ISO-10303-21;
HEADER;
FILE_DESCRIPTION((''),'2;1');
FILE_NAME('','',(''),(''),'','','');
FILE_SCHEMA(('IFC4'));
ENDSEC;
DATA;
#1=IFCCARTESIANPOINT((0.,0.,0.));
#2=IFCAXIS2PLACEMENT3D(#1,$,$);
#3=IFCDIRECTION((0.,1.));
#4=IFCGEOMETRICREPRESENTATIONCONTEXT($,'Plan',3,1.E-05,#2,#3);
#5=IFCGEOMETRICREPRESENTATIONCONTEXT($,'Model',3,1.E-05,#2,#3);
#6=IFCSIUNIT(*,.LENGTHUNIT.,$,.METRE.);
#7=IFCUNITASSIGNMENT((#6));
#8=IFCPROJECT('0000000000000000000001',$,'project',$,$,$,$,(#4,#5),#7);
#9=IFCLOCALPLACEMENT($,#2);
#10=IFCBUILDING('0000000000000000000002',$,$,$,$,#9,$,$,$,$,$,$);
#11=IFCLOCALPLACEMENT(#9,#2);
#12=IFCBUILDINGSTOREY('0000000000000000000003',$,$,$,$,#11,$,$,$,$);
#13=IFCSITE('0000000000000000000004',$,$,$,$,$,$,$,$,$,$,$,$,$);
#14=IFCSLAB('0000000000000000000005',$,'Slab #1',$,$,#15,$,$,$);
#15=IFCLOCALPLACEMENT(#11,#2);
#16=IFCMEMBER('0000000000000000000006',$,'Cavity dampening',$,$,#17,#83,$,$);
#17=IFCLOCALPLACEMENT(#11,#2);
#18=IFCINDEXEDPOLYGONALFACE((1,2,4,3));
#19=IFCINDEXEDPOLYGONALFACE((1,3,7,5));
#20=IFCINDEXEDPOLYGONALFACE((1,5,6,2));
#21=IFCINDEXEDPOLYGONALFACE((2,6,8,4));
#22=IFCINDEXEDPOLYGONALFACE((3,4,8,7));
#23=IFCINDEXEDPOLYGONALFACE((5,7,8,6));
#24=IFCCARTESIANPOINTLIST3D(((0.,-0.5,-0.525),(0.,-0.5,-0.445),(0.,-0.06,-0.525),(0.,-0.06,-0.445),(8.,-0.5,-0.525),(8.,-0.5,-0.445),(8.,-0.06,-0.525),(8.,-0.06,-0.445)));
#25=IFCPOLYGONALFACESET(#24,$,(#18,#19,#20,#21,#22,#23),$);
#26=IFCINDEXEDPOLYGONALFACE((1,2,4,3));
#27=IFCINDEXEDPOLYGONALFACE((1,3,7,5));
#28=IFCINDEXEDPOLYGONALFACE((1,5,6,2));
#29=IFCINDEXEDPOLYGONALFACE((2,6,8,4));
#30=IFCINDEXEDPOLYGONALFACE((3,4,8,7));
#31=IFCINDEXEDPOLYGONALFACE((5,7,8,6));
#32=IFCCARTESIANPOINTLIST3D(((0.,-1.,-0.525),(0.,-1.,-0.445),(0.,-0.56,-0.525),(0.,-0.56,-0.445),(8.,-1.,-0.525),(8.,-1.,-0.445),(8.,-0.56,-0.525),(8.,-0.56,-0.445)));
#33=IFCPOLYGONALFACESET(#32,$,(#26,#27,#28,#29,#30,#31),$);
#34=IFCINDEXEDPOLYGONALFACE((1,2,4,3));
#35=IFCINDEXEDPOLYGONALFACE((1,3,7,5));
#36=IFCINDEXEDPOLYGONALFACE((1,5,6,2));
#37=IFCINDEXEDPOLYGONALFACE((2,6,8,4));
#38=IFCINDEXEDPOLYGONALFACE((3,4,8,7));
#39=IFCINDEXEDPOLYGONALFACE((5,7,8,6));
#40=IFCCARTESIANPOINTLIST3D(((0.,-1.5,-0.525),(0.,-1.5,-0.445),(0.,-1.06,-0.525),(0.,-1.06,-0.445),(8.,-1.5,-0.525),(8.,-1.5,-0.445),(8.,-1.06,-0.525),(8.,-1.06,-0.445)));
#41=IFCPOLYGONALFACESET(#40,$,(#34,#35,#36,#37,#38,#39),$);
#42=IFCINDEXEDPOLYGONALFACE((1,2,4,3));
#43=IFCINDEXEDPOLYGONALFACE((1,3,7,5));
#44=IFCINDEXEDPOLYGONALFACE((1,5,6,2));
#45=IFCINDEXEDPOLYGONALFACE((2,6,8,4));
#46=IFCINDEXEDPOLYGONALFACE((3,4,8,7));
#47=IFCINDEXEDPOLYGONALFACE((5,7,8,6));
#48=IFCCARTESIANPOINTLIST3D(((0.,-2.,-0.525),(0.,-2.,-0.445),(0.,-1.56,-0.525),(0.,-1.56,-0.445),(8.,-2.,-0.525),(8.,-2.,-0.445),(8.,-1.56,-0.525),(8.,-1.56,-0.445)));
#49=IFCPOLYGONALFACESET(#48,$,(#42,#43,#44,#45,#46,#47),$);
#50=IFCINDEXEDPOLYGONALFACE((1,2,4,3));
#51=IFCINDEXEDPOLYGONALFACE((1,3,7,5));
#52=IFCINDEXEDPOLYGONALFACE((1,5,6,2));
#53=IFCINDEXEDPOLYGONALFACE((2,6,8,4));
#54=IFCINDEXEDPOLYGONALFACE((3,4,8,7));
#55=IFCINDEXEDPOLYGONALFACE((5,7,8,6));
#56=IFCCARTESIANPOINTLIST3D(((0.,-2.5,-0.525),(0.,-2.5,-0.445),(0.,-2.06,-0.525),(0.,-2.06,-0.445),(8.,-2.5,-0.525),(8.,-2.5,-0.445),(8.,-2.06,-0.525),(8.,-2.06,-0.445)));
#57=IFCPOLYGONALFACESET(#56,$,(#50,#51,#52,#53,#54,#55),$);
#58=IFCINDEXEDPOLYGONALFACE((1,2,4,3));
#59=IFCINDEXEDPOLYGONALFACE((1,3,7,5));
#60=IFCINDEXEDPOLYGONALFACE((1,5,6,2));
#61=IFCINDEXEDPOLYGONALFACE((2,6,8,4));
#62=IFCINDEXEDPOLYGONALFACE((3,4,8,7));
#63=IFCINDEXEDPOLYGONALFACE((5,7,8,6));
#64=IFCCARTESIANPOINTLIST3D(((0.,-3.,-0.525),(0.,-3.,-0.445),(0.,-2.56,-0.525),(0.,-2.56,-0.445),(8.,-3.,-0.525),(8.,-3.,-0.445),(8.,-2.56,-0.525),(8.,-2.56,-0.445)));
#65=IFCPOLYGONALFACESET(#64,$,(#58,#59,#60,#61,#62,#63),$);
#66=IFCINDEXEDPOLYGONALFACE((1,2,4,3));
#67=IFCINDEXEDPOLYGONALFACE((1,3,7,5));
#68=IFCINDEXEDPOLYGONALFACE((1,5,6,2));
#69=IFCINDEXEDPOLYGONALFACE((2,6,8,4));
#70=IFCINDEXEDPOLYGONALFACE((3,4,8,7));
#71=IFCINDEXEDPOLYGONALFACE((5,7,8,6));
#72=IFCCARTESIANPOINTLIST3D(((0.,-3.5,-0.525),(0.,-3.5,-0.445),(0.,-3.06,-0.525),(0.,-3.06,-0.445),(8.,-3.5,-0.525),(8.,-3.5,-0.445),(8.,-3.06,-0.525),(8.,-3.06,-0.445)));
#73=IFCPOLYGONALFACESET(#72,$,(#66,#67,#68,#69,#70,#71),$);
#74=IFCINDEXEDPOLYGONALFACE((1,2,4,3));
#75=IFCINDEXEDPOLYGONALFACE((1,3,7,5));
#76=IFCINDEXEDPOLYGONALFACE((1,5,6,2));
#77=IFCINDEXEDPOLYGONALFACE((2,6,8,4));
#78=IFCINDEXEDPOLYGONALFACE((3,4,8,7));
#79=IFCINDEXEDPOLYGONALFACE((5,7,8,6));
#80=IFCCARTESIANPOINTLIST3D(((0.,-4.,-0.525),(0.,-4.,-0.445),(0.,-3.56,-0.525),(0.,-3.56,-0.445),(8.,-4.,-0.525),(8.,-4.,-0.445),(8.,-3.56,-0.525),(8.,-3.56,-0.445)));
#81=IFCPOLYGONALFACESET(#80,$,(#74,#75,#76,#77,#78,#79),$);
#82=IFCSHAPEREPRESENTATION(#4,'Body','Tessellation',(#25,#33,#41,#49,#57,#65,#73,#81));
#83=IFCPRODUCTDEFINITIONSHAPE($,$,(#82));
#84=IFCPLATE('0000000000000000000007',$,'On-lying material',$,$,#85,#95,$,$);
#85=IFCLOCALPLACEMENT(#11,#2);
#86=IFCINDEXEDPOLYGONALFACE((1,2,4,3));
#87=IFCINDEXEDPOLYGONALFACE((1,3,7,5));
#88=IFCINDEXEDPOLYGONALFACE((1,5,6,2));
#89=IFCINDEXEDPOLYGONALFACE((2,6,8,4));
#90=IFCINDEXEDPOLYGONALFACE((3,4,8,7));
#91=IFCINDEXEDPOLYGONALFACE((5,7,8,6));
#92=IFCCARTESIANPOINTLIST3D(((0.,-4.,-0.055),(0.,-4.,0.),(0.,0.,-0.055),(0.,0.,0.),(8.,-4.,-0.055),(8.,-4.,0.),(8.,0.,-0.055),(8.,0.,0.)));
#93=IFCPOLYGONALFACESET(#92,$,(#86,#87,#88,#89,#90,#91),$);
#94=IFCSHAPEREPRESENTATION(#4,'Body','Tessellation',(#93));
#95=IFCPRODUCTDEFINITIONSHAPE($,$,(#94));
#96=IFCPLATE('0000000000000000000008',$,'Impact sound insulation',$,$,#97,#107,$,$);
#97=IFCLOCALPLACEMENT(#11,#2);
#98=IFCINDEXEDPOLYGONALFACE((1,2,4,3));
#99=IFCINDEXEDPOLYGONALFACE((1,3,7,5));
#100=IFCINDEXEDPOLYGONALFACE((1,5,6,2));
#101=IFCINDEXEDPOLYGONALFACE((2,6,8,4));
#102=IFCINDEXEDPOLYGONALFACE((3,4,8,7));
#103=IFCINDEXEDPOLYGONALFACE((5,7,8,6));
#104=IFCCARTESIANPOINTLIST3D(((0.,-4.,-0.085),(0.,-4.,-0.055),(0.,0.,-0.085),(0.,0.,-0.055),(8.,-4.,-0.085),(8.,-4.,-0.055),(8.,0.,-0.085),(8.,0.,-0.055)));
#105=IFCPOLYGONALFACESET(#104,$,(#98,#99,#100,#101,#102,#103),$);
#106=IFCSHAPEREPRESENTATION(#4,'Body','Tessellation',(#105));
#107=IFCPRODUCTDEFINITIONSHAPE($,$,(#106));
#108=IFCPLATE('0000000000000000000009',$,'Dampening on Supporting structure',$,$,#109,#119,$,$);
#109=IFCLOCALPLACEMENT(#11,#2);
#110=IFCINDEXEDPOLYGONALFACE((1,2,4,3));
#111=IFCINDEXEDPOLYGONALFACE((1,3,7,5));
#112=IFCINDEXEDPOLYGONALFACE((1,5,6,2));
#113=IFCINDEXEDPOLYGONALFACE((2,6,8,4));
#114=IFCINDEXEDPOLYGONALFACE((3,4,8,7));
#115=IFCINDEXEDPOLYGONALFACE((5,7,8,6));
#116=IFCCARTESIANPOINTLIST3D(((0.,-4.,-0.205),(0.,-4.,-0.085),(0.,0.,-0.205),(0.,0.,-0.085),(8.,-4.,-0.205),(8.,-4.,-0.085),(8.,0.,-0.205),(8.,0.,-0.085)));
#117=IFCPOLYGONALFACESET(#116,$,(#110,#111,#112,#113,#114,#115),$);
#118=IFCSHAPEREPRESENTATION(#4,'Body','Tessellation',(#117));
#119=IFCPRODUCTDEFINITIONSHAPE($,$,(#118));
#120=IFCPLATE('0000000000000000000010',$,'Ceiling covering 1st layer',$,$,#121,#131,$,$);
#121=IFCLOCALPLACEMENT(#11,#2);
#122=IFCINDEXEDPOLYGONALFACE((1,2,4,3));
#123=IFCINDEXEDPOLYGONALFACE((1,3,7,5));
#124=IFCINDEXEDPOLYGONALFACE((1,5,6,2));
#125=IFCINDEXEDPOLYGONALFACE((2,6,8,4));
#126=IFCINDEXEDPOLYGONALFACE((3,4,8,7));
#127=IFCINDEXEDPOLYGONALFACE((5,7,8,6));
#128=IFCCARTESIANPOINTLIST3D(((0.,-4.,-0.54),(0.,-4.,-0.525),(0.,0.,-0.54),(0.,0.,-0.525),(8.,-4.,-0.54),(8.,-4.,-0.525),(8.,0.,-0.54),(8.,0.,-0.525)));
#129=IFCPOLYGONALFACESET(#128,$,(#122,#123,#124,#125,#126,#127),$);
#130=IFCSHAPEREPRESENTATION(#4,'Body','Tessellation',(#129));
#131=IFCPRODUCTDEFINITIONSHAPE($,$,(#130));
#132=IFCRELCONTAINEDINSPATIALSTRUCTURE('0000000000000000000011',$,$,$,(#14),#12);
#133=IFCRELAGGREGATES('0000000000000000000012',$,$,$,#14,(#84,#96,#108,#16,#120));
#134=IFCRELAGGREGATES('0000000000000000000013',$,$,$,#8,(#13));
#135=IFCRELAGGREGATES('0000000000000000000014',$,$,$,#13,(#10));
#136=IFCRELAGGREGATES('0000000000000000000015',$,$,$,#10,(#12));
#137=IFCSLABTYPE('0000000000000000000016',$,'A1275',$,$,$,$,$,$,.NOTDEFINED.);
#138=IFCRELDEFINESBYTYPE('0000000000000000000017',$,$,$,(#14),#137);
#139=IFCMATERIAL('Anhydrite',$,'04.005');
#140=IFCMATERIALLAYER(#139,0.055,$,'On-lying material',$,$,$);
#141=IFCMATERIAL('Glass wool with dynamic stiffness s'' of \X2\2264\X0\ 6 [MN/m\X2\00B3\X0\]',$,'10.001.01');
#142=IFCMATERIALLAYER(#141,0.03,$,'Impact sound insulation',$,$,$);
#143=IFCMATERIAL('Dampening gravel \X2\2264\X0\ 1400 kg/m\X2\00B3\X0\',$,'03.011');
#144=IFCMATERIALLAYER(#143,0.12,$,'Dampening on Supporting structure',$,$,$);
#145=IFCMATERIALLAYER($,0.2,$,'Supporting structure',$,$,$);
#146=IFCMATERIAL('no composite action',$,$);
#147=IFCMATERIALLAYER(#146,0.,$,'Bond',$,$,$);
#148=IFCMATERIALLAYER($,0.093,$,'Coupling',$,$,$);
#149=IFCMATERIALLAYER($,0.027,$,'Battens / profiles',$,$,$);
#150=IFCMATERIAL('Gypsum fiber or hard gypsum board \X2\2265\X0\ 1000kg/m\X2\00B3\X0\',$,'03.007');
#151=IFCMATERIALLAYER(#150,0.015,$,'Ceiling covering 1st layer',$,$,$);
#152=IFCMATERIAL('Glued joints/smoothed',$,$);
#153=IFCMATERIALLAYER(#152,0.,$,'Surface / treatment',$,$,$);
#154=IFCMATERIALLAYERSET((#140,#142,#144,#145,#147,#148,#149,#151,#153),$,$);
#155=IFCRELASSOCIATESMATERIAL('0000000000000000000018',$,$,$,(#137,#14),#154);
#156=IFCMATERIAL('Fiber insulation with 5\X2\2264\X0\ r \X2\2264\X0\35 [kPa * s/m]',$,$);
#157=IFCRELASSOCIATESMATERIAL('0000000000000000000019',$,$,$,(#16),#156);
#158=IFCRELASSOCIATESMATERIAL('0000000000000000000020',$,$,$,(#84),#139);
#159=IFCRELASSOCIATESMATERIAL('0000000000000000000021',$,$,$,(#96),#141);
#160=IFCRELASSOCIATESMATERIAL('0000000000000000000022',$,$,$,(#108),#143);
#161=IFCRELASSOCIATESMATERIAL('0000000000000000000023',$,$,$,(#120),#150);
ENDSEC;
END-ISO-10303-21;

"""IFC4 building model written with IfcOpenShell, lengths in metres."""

from ifc_helpers import new_model, si_unit, direction, frame, frame_2d, origin, origin_with_axes, place, context, project, spatial, rectangle, extrude, material, layer, layer_set, type_object, element, aggregate, save


model = new_model("IFC4")

# Units and contexts
plan_context = context("Plan", 3, precision=1e-05, world=origin(), true_north=direction((0.0, 1.0)))
model_context = context("Model", 3, precision=1e-05, world=origin(), true_north=direction((0.0, 1.0)))
ifc_project = project(units=[si_unit("LENGTHUNIT", "METRE")], contexts=[plan_context, model_context])

# Site, building, storey
site = spatial("IfcSite", under=ifc_project)
building_placement = place(None, origin())
building = spatial("IfcBuilding", under=site, at=building_placement)
storey_placement = place(building_placement, origin())
storey = spatial("IfcBuildingStorey", under=building, at=storey_placement)

# Slab, member, plates
ifc_material_1 = material(Name="Anhydrite", Category="04.005")
ifc_layer_1 = layer(ifc_material_1, 0.055, Name="On-lying material")
ifc_material_2 = material(Name="Glass wool with dynamic stiffness s' of ≤ 6 [MN/m³]", Category="10.001.01")
ifc_layer_2 = layer(ifc_material_2, 0.03, Name="Impact sound insulation")
ifc_material_3 = material(Name="Dampening gravel ≤ 1400 kg/m³", Category="03.011")
ifc_layer_3 = layer(ifc_material_3, 0.12, Name="Dampening on Supporting structure")
ifc_layer_4 = layer(None, 0.2, Name="Supporting structure")
ifc_material_4 = material(Name="no composite action")
ifc_layer_5 = layer(ifc_material_4, 0.0, Name="Bond")
ifc_layer_6 = layer(None, 0.093, Name="Coupling")
ifc_layer_7 = layer(None, 0.027, Name="Battens / profiles")
ifc_material_5 = material(Name="Gypsum fiber or hard gypsum board ≥ 1000kg/m³", Category="03.007")
ifc_layer_8 = layer(ifc_material_5, 0.015, Name="Ceiling covering 1st layer")
ifc_material_6 = material(Name="Glued joints/smoothed")
ifc_layer_9 = layer(ifc_material_6, 0.0, Name="Surface / treatment")
ifc_layer_set = layer_set([ifc_layer_1, ifc_layer_2, ifc_layer_3, ifc_layer_4, ifc_layer_5, ifc_layer_6, ifc_layer_7, ifc_layer_8, ifc_layer_9])
slab_type = type_object("IfcSlabType", Name="A1275", PredefinedType="NOTDEFINED", material=ifc_layer_set)
slab_placement = place(None, frame((0.0, 0.0, 0.0), z_axis=(0.0, 0.0, -1.0), x_axis=(1.0, 0.0, 0.0)))
slab = element("IfcSlab", 1, at=slab_placement, inside=storey, type_object=slab_type, material=ifc_layer_set, Name="Slab #1")
ifc_material_7 = material(Name="Fiber insulation with 5≤ r ≤35 [kPa * s/m]")
member_1_placement = place(slab_placement, origin())
member_1 = element("IfcMember", 2, at=member_1_placement, material=ifc_material_7, Name="Cavity dampening", context=plan_context, shape_type="SweptSolid", body=[
    extrude(rectangle(XDim=0.44, YDim=0.08, at=frame_2d((0.22, 0.04), x_axis=(1.0, 0.0))), frame((0.0, 0.06, 0.445), z_axis=(1.0, 0.0, 0.0), x_axis=(0.0, 1.0, 0.0)), (0.0, 0.0, 1.0), 8.0),
    extrude(rectangle(XDim=0.44, YDim=0.08, at=frame_2d((0.22, 0.04), x_axis=(1.0, 0.0))), frame((0.0, 0.56, 0.445), z_axis=(1.0, 0.0, 0.0), x_axis=(0.0, 1.0, 0.0)), (0.0, 0.0, 1.0), 8.0),
    extrude(rectangle(XDim=0.44, YDim=0.08, at=frame_2d((0.22, 0.04), x_axis=(1.0, 0.0))), frame((0.0, 1.06, 0.445), z_axis=(1.0, 0.0, 0.0), x_axis=(0.0, 1.0, 0.0)), (0.0, 0.0, 1.0), 8.0),
    extrude(rectangle(XDim=0.44, YDim=0.08, at=frame_2d((0.22, 0.04), x_axis=(1.0, 0.0))), frame((0.0, 1.56, 0.445), z_axis=(1.0, 0.0, 0.0), x_axis=(0.0, 1.0, 0.0)), (0.0, 0.0, 1.0), 8.0),
    extrude(rectangle(XDim=0.44, YDim=0.08, at=frame_2d((0.22, 0.04), x_axis=(1.0, 0.0))), frame((0.0, 2.06, 0.445), z_axis=(1.0, 0.0, 0.0), x_axis=(0.0, 1.0, 0.0)), (0.0, 0.0, 1.0), 8.0),
    extrude(rectangle(XDim=0.44, YDim=0.08, at=frame_2d((0.22, 0.04), x_axis=(1.0, 0.0))), frame((0.0, 2.56, 0.445), z_axis=(1.0, 0.0, 0.0), x_axis=(0.0, 1.0, 0.0)), (0.0, 0.0, 1.0), 8.0),
    extrude(rectangle(XDim=0.44, YDim=0.08, at=frame_2d((0.22, 0.04), x_axis=(1.0, 0.0))), frame((0.0, 3.06, 0.445), z_axis=(1.0, 0.0, 0.0), x_axis=(0.0, 1.0, 0.0)), (0.0, 0.0, 1.0), 8.0),
    extrude(rectangle(XDim=0.44, YDim=0.08, at=frame_2d((0.22, 0.04), x_axis=(1.0, 0.0))), frame((0.0, 3.56, 0.445), z_axis=(1.0, 0.0, 0.0), x_axis=(0.0, 1.0, 0.0)), (0.0, 0.0, 1.0), 8.0),
])
plate_1_placement = place(slab_placement, origin())
plate_1 = element("IfcPlate", 3, at=plate_1_placement, material=ifc_material_1, Name="On-lying material", context=plan_context, shape_type="SweptSolid", body=[
    extrude(rectangle(XDim=8.0, YDim=4.0, at=frame_2d((4.0, 2.0), x_axis=(1.0, 0.0))), origin_with_axes(), (0.0, 0.0, 1.0), 0.055),
])
plate_2_placement = place(slab_placement, origin())
plate_2 = element("IfcPlate", 4, at=plate_2_placement, material=ifc_material_2, Name="Impact sound insulation", context=plan_context, shape_type="SweptSolid", body=[
    extrude(rectangle(XDim=8.0, YDim=4.0, at=frame_2d((4.0, 2.0), x_axis=(1.0, 0.0))), frame((0.0, 0.0, 0.055), z_axis=(0.0, 0.0, 1.0), x_axis=(1.0, 0.0, 0.0)), (0.0, 0.0, 1.0), 0.03),
])
plate_3_placement = place(slab_placement, origin())
plate_3 = element("IfcPlate", 5, at=plate_3_placement, material=ifc_material_3, Name="Dampening on Supporting structure", context=plan_context, shape_type="SweptSolid", body=[
    extrude(rectangle(XDim=8.0, YDim=4.0, at=frame_2d((4.0, 2.0), x_axis=(1.0, 0.0))), frame((0.0, 0.0, 0.085), z_axis=(0.0, 0.0, 1.0), x_axis=(1.0, 0.0, 0.0)), (0.0, 0.0, 1.0), 0.12),
])
plate_4_placement = place(slab_placement, origin())
plate_4 = element("IfcPlate", 6, at=plate_4_placement, material=ifc_material_5, Name="Ceiling covering 1st layer", context=plan_context, shape_type="SweptSolid", body=[
    extrude(rectangle(XDim=8.0, YDim=4.0, at=frame_2d((4.0, 2.0), x_axis=(1.0, 0.0))), frame((0.0, 0.0, 0.525), z_axis=(0.0, 0.0, 1.0), x_axis=(1.0, 0.0, 0.0)), (0.0, 0.0, 1.0), 0.015),
])
aggregate(slab, [plate_1, plate_2, plate_3, member_1, plate_4])

save(model, "model.ifc")
